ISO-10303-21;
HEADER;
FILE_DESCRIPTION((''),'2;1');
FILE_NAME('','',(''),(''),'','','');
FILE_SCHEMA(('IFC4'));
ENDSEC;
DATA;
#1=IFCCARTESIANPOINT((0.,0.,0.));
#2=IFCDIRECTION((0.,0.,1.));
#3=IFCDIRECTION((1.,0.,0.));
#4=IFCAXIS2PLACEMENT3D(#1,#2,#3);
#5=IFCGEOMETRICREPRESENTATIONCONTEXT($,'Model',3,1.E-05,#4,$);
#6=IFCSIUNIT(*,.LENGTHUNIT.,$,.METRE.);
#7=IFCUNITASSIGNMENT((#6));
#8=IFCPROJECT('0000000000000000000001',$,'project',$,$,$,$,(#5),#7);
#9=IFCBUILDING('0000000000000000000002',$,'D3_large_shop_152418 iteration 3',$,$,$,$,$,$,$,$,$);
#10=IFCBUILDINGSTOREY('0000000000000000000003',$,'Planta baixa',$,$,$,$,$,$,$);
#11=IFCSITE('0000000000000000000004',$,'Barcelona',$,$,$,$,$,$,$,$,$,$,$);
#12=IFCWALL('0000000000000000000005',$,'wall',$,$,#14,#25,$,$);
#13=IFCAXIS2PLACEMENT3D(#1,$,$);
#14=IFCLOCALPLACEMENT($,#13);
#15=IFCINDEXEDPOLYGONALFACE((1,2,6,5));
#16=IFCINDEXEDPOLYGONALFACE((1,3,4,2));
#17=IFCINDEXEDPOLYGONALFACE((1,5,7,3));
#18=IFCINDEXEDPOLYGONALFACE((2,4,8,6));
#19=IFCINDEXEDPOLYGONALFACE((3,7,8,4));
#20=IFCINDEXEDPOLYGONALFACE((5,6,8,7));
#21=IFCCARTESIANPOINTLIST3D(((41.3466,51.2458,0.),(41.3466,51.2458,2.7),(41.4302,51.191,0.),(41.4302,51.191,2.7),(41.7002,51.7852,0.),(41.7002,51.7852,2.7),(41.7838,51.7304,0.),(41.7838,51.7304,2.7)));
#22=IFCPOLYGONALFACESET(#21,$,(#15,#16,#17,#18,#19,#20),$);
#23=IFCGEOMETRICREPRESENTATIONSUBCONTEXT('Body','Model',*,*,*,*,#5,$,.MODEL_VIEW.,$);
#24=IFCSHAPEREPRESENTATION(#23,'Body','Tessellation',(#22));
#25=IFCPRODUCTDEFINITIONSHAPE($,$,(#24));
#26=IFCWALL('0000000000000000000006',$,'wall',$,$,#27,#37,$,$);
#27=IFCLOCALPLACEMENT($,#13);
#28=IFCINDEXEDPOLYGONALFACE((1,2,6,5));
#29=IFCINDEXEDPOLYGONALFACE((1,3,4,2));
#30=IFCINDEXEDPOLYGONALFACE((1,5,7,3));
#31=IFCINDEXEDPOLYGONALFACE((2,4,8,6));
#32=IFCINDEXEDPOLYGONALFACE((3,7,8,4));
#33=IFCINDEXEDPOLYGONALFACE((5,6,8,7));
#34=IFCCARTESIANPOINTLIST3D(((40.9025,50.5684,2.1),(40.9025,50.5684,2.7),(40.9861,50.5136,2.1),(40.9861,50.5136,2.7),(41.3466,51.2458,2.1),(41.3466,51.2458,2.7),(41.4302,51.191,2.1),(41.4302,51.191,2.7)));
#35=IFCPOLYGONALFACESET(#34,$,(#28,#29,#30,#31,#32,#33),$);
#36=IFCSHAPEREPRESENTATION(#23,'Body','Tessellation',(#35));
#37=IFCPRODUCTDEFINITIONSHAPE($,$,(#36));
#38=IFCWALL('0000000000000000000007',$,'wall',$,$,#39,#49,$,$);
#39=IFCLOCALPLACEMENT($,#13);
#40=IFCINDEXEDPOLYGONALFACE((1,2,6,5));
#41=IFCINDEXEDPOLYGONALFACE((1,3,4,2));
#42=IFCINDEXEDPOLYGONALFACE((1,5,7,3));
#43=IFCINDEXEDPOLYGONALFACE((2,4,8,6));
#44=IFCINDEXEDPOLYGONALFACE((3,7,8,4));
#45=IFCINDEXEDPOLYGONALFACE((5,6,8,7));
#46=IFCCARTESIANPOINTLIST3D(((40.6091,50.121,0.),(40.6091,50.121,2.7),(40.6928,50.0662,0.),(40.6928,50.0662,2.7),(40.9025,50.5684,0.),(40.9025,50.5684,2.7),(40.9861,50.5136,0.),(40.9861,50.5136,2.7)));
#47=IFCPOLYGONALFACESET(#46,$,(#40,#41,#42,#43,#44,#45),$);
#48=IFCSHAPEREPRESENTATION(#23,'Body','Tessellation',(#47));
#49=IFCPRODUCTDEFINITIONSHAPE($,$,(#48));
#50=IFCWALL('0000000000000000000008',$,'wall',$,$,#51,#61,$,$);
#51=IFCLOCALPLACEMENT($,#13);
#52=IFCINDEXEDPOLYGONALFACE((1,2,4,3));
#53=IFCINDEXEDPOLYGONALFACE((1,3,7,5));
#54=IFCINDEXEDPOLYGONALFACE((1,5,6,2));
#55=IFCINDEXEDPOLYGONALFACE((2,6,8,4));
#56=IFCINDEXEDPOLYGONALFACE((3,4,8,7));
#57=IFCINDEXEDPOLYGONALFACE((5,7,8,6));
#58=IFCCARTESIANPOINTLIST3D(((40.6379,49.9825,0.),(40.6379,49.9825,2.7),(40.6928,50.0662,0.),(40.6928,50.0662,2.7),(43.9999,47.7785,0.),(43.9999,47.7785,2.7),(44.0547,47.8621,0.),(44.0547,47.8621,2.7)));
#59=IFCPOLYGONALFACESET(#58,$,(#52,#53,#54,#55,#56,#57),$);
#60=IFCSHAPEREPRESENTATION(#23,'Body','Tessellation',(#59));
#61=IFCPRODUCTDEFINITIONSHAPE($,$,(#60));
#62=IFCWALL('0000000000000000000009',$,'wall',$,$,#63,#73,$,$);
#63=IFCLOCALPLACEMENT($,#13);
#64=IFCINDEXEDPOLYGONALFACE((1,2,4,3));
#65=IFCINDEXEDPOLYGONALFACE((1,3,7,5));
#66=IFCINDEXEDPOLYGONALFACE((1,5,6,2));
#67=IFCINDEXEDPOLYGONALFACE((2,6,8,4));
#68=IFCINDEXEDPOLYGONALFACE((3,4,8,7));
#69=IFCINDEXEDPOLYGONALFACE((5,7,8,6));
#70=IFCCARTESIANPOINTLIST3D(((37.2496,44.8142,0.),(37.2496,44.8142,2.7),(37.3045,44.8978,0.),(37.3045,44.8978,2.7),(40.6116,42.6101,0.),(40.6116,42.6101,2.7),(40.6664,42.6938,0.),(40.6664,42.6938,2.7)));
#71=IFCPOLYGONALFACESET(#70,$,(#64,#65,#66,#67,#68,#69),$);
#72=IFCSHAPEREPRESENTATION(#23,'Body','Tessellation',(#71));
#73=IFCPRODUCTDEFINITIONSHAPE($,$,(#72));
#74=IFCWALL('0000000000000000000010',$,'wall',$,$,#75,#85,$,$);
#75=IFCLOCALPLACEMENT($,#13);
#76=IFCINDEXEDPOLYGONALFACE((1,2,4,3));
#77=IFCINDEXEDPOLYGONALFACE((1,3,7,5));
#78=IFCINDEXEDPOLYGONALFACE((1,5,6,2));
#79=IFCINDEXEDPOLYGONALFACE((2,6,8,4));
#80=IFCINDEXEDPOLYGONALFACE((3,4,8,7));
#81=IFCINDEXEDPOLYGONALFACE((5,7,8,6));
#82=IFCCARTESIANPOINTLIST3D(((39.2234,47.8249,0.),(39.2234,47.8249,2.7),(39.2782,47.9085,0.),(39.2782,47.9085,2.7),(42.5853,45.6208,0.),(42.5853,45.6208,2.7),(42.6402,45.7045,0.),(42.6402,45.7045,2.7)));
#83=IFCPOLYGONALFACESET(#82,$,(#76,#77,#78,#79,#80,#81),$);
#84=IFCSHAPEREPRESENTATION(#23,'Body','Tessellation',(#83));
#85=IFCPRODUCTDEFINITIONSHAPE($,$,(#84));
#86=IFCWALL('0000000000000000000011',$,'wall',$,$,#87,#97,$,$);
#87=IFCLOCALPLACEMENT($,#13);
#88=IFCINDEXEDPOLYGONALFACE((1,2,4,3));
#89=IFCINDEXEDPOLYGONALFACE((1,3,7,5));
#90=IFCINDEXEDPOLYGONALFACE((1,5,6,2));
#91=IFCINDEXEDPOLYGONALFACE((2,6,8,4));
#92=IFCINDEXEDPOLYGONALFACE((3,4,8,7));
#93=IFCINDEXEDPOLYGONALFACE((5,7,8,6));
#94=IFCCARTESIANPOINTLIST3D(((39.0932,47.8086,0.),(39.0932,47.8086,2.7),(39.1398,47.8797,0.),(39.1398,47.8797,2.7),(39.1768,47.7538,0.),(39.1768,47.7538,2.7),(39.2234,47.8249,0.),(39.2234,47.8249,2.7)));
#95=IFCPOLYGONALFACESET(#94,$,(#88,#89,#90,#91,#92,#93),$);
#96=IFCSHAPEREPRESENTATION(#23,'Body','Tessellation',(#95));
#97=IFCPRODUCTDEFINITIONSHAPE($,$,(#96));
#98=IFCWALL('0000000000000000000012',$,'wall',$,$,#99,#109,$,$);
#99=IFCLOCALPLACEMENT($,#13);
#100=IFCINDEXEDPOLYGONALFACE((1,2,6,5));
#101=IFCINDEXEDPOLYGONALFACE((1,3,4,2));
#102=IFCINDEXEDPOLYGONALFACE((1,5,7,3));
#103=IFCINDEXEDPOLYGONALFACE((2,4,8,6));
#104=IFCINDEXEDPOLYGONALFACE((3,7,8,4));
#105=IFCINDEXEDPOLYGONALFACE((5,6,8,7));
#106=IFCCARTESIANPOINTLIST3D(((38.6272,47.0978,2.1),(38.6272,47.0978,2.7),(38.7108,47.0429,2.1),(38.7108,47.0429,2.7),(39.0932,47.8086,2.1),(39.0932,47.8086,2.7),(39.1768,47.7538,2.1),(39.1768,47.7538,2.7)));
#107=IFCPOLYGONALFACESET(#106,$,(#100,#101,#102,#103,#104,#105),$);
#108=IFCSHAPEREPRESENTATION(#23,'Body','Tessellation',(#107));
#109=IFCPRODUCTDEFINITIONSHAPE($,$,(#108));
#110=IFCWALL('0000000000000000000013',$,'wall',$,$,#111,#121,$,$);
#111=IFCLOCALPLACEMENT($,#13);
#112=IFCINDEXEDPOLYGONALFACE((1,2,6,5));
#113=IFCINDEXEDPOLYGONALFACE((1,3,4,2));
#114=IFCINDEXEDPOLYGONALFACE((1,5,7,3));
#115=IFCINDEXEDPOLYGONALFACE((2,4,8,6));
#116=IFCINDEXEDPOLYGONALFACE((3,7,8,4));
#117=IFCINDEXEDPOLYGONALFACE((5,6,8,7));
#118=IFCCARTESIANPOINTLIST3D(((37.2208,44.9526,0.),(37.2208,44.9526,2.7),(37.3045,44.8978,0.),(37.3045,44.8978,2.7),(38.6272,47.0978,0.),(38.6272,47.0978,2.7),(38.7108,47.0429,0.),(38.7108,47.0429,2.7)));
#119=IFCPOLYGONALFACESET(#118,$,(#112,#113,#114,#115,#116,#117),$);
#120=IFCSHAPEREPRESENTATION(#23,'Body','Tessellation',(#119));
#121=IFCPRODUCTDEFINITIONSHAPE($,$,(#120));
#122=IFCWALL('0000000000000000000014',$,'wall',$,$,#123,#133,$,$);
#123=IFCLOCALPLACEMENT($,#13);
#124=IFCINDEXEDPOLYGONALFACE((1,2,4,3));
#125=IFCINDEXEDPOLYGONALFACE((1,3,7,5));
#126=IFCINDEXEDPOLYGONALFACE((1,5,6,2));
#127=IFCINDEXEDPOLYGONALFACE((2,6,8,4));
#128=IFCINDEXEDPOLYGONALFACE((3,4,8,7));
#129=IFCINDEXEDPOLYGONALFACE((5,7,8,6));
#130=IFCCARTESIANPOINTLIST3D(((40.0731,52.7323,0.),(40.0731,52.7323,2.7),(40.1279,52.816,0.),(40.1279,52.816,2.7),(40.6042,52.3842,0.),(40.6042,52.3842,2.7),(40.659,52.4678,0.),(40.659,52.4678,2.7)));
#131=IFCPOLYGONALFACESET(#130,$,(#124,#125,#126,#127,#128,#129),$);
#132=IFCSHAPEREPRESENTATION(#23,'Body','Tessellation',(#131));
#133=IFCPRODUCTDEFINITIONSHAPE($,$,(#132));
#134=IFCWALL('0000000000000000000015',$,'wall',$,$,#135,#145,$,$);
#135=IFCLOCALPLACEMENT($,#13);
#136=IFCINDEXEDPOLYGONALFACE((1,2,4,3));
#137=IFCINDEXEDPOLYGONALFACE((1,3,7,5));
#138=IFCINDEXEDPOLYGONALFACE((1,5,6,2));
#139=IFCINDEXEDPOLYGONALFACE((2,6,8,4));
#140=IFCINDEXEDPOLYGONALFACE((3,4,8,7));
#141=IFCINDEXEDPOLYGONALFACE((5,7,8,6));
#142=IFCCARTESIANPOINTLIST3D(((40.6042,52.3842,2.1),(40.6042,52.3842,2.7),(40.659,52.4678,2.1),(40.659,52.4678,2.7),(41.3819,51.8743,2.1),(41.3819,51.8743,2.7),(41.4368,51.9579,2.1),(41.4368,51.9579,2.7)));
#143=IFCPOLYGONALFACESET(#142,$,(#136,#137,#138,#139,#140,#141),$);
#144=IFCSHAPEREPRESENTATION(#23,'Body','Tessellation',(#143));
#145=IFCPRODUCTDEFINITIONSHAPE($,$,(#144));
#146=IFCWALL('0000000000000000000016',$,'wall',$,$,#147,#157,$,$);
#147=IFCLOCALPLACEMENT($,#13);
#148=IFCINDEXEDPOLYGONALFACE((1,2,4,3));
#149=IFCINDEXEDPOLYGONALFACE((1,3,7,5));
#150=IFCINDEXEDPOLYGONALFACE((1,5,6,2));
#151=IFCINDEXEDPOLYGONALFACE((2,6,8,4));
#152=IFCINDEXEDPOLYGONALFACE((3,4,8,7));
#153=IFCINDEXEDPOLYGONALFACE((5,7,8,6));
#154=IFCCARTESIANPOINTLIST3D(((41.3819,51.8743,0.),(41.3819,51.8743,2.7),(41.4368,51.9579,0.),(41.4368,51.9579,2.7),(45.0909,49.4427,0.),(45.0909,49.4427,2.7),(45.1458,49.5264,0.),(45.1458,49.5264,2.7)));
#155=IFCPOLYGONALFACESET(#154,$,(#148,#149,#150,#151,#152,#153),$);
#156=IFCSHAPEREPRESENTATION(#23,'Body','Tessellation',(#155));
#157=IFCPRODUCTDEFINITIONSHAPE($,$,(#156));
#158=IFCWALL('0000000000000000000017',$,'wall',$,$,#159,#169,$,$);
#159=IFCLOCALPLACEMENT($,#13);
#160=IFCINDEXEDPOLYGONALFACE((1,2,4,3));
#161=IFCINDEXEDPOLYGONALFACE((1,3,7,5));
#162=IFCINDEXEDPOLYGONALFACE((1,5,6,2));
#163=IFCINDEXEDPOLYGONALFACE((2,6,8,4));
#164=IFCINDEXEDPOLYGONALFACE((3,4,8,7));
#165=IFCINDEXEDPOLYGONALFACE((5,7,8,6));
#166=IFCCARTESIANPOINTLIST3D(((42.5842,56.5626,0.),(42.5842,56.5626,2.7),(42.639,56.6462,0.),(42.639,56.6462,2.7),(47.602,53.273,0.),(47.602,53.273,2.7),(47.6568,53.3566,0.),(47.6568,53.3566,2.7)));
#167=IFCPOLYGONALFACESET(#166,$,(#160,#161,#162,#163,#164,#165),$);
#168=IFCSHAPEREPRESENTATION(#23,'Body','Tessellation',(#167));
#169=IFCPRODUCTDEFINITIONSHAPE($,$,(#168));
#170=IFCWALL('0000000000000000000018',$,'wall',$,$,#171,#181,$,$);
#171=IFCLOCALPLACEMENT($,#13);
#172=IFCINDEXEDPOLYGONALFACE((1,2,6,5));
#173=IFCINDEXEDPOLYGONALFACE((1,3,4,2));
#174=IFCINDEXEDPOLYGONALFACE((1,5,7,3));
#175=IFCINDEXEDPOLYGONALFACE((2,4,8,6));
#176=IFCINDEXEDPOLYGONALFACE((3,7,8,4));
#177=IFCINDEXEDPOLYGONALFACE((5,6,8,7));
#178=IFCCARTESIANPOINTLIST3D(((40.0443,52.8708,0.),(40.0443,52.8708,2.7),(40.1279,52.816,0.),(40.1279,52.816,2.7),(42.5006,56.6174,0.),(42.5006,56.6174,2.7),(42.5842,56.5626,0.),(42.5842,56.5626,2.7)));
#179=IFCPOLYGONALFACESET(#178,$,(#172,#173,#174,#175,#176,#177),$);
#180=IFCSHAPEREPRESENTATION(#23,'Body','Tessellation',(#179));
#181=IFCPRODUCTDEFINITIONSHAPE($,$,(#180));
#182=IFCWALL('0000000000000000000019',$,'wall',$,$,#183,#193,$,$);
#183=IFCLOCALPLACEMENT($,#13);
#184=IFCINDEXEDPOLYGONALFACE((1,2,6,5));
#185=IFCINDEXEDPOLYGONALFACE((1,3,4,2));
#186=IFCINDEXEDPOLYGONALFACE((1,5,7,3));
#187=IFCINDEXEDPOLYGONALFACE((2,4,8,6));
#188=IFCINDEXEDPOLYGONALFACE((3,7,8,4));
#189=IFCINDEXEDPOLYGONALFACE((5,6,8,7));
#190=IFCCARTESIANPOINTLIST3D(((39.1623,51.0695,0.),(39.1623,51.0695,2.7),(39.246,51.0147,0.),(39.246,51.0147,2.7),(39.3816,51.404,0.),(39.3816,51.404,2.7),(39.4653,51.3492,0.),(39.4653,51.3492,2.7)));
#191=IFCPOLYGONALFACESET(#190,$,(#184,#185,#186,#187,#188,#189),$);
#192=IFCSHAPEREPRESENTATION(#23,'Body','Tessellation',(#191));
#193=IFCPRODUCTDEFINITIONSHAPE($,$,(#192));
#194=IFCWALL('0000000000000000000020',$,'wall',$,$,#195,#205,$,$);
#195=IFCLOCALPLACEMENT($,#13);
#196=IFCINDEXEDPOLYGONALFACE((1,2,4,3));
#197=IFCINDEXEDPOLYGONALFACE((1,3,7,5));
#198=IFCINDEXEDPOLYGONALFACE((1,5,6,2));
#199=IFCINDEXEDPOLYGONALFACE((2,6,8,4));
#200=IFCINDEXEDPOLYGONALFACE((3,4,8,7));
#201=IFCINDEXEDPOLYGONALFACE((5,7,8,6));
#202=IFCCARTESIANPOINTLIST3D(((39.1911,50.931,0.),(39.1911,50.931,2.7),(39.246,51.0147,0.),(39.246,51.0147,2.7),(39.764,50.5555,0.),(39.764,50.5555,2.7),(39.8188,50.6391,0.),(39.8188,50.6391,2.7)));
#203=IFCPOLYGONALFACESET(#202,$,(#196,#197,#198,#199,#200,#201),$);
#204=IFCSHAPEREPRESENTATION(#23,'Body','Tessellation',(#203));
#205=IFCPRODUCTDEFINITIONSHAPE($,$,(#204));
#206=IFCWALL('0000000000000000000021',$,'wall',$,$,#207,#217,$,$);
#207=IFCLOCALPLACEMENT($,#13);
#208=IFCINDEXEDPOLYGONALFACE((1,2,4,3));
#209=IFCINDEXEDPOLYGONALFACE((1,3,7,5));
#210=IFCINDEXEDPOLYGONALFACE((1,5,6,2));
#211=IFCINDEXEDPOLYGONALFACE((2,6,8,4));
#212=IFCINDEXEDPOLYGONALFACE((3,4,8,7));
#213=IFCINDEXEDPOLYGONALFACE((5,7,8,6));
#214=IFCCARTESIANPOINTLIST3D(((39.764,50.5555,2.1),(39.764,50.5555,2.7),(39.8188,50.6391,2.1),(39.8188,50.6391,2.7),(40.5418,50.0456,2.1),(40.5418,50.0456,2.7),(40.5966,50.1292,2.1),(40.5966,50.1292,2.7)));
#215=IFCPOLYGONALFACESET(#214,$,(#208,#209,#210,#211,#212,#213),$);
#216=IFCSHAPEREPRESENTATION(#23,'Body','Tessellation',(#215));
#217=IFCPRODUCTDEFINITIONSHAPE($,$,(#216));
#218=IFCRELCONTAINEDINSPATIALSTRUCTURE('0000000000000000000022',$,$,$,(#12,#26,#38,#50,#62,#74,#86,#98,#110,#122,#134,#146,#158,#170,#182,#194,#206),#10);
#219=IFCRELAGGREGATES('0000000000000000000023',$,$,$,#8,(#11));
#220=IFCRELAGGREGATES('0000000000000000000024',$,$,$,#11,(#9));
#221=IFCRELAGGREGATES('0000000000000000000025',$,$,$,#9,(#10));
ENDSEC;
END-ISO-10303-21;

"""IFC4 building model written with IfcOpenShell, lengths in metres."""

from ifc_helpers import new_model, si_unit, frame, origin, origin_with_axes, place, context, subcontext, project, spatial, polyline, outline, extrude, element, save


model = new_model("IFC4")

# Units and contexts
model_context = context("Model", 3, precision=1e-05, world=origin_with_axes())
body_context = subcontext(model_context, "Body", "Model", "MODEL_VIEW")
ifc_project = project(units=[si_unit("LENGTHUNIT", "METRE")], contexts=[model_context])

# Site, building, storey
site = spatial("IfcSite", under=ifc_project, Name="Barcelona")
building = spatial("IfcBuilding", under=site, Name="D3_large_shop_152418 iteration 3")
storey = spatial("IfcBuildingStorey", under=building, Name="Planta baixa")

# Walls
wall_1_placement = place(None, origin_with_axes())
element("IfcWall", 1, at=wall_1_placement, inside=storey, Name="wall", context=body_context, shape_type="SweptSolid", body=[
    extrude(outline(polyline([(41.7838, 51.7304), (41.4302, 51.191), (41.3466, 51.2458), (41.7002, 51.7852), (41.7838, 51.7304)])), origin(), (0.0, 0.0, 1.0), 2.7),
])
wall_2_placement = place(None, origin_with_axes())
element("IfcWall", 2, at=wall_2_placement, inside=storey, Name="wall", context=body_context, shape_type="SweptSolid", body=[
    extrude(outline(polyline([(41.4302, 51.191), (40.9861, 50.5136), (40.9025, 50.5684), (41.3466, 51.2458), (41.4302, 51.191)])), frame((0.0, 0.0, 2.1)), (0.0, 0.0, 1.0), 0.6),
])
wall_3_placement = place(None, origin_with_axes())
element("IfcWall", 3, at=wall_3_placement, inside=storey, Name="wall", context=body_context, shape_type="SweptSolid", body=[
    extrude(outline(polyline([(40.9861, 50.5136), (40.6928, 50.0662), (40.6091, 50.121), (40.9025, 50.5684), (40.9861, 50.5136)])), origin(), (0.0, 0.0, 1.0), 2.7),
])
wall_4_placement = place(None, origin_with_axes())
element("IfcWall", 4, at=wall_4_placement, inside=storey, Name="wall", context=body_context, shape_type="SweptSolid", body=[
    extrude(outline(polyline([(40.6928, 50.0662), (44.0547, 47.8621), (43.9999, 47.7785), (40.6379, 49.9825), (40.6928, 50.0662)])), origin(), (0.0, 0.0, 1.0), 2.7),
])
wall_5_placement = place(None, origin_with_axes())
element("IfcWall", 5, at=wall_5_placement, inside=storey, Name="wall", context=body_context, shape_type="SweptSolid", body=[
    extrude(outline(polyline([(37.3045, 44.8978), (40.6664, 42.6938), (40.6116, 42.6101), (37.2496, 44.8142), (37.3045, 44.8978)])), origin(), (0.0, 0.0, 1.0), 2.7),
])
wall_6_placement = place(None, origin_with_axes())
element("IfcWall", 6, at=wall_6_placement, inside=storey, Name="wall", context=body_context, shape_type="SweptSolid", body=[
    extrude(outline(polyline([(42.5853, 45.6208), (39.2234, 47.8249), (39.2782, 47.9085), (42.6402, 45.7045), (42.5853, 45.6208)])), origin(), (0.0, 0.0, 1.0), 2.7),
])
wall_7_placement = place(None, origin_with_axes())
element("IfcWall", 7, at=wall_7_placement, inside=storey, Name="wall", context=body_context, shape_type="SweptSolid", body=[
    extrude(outline(polyline([(39.2234, 47.8249), (39.1768, 47.7538), (39.0932, 47.8086), (39.1398, 47.8797), (39.2234, 47.8249)])), origin(), (0.0, 0.0, 1.0), 2.7),
])
wall_8_placement = place(None, origin_with_axes())
element("IfcWall", 8, at=wall_8_placement, inside=storey, Name="wall", context=body_context, shape_type="SweptSolid", body=[
    extrude(outline(polyline([(39.1768, 47.7538), (38.7108, 47.0429), (38.6272, 47.0978), (39.0932, 47.8086), (39.1768, 47.7538)])), frame((0.0, 0.0, 2.1)), (0.0, 0.0, 1.0), 0.6),
])
wall_9_placement = place(None, origin_with_axes())
element("IfcWall", 9, at=wall_9_placement, inside=storey, Name="wall", context=body_context, shape_type="SweptSolid", body=[
    extrude(outline(polyline([(38.7108, 47.0429), (37.3045, 44.8978), (37.2208, 44.9526), (38.6272, 47.0978), (38.7108, 47.0429)])), origin(), (0.0, 0.0, 1.0), 2.7),
])
wall_10_placement = place(None, origin_with_axes())
element("IfcWall", 10, at=wall_10_placement, inside=storey, Name="wall", context=body_context, shape_type="SweptSolid", body=[
    extrude(outline(polyline([(40.1279, 52.816), (40.659, 52.4678), (40.6042, 52.3842), (40.0731, 52.7323), (40.1279, 52.816)])), origin(), (0.0, 0.0, 1.0), 2.7),
])
wall_11_placement = place(None, origin_with_axes())
element("IfcWall", 11, at=wall_11_placement, inside=storey, Name="wall", context=body_context, shape_type="SweptSolid", body=[
    extrude(outline(polyline([(40.659, 52.4678), (41.4368, 51.9579), (41.3819, 51.8743), (40.6042, 52.3842), (40.659, 52.4678)])), frame((0.0, 0.0, 2.1)), (0.0, 0.0, 1.0), 0.6),
])
wall_12_placement = place(None, origin_with_axes())
element("IfcWall", 12, at=wall_12_placement, inside=storey, Name="wall", context=body_context, shape_type="SweptSolid", body=[
    extrude(outline(polyline([(41.4368, 51.9579), (45.1458, 49.5264), (45.0909, 49.4427), (41.3819, 51.8743), (41.4368, 51.9579)])), origin(), (0.0, 0.0, 1.0), 2.7),
])
wall_13_placement = place(None, origin_with_axes())
element("IfcWall", 13, at=wall_13_placement, inside=storey, Name="wall", context=body_context, shape_type="SweptSolid", body=[
    extrude(outline(polyline([(47.602, 53.273), (42.5842, 56.5626), (42.639, 56.6462), (47.6568, 53.3566), (47.602, 53.273)])), origin(), (0.0, 0.0, 1.0), 2.7),
])
wall_14_placement = place(None, origin_with_axes())
element("IfcWall", 14, at=wall_14_placement, inside=storey, Name="wall", context=body_context, shape_type="SweptSolid", body=[
    extrude(outline(polyline([(42.5842, 56.5626), (40.1279, 52.816), (40.0443, 52.8708), (42.5006, 56.6174), (42.5842, 56.5626)])), origin(), (0.0, 0.0, 1.0), 2.7),
])
wall_15_placement = place(None, origin_with_axes())
element("IfcWall", 15, at=wall_15_placement, inside=storey, Name="wall", context=body_context, shape_type="SweptSolid", body=[
    extrude(outline(polyline([(39.4653, 51.3492), (39.246, 51.0147), (39.1623, 51.0695), (39.3816, 51.404), (39.4653, 51.3492)])), origin(), (0.0, 0.0, 1.0), 2.7),
])
wall_16_placement = place(None, origin_with_axes())
element("IfcWall", 16, at=wall_16_placement, inside=storey, Name="wall", context=body_context, shape_type="SweptSolid", body=[
    extrude(outline(polyline([(39.246, 51.0147), (39.8188, 50.6391), (39.764, 50.5555), (39.1911, 50.931), (39.246, 51.0147)])), origin(), (0.0, 0.0, 1.0), 2.7),
])
wall_17_placement = place(None, origin_with_axes())
element("IfcWall", 17, at=wall_17_placement, inside=storey, Name="wall", context=body_context, shape_type="SweptSolid", body=[
    extrude(outline(polyline([(39.8188, 50.6391), (40.5966, 50.1292), (40.5418, 50.0456), (39.764, 50.5555), (39.8188, 50.6391)])), frame((0.0, 0.0, 2.1)), (0.0, 0.0, 1.0), 0.6),
])

save(model, "model.ifc")
